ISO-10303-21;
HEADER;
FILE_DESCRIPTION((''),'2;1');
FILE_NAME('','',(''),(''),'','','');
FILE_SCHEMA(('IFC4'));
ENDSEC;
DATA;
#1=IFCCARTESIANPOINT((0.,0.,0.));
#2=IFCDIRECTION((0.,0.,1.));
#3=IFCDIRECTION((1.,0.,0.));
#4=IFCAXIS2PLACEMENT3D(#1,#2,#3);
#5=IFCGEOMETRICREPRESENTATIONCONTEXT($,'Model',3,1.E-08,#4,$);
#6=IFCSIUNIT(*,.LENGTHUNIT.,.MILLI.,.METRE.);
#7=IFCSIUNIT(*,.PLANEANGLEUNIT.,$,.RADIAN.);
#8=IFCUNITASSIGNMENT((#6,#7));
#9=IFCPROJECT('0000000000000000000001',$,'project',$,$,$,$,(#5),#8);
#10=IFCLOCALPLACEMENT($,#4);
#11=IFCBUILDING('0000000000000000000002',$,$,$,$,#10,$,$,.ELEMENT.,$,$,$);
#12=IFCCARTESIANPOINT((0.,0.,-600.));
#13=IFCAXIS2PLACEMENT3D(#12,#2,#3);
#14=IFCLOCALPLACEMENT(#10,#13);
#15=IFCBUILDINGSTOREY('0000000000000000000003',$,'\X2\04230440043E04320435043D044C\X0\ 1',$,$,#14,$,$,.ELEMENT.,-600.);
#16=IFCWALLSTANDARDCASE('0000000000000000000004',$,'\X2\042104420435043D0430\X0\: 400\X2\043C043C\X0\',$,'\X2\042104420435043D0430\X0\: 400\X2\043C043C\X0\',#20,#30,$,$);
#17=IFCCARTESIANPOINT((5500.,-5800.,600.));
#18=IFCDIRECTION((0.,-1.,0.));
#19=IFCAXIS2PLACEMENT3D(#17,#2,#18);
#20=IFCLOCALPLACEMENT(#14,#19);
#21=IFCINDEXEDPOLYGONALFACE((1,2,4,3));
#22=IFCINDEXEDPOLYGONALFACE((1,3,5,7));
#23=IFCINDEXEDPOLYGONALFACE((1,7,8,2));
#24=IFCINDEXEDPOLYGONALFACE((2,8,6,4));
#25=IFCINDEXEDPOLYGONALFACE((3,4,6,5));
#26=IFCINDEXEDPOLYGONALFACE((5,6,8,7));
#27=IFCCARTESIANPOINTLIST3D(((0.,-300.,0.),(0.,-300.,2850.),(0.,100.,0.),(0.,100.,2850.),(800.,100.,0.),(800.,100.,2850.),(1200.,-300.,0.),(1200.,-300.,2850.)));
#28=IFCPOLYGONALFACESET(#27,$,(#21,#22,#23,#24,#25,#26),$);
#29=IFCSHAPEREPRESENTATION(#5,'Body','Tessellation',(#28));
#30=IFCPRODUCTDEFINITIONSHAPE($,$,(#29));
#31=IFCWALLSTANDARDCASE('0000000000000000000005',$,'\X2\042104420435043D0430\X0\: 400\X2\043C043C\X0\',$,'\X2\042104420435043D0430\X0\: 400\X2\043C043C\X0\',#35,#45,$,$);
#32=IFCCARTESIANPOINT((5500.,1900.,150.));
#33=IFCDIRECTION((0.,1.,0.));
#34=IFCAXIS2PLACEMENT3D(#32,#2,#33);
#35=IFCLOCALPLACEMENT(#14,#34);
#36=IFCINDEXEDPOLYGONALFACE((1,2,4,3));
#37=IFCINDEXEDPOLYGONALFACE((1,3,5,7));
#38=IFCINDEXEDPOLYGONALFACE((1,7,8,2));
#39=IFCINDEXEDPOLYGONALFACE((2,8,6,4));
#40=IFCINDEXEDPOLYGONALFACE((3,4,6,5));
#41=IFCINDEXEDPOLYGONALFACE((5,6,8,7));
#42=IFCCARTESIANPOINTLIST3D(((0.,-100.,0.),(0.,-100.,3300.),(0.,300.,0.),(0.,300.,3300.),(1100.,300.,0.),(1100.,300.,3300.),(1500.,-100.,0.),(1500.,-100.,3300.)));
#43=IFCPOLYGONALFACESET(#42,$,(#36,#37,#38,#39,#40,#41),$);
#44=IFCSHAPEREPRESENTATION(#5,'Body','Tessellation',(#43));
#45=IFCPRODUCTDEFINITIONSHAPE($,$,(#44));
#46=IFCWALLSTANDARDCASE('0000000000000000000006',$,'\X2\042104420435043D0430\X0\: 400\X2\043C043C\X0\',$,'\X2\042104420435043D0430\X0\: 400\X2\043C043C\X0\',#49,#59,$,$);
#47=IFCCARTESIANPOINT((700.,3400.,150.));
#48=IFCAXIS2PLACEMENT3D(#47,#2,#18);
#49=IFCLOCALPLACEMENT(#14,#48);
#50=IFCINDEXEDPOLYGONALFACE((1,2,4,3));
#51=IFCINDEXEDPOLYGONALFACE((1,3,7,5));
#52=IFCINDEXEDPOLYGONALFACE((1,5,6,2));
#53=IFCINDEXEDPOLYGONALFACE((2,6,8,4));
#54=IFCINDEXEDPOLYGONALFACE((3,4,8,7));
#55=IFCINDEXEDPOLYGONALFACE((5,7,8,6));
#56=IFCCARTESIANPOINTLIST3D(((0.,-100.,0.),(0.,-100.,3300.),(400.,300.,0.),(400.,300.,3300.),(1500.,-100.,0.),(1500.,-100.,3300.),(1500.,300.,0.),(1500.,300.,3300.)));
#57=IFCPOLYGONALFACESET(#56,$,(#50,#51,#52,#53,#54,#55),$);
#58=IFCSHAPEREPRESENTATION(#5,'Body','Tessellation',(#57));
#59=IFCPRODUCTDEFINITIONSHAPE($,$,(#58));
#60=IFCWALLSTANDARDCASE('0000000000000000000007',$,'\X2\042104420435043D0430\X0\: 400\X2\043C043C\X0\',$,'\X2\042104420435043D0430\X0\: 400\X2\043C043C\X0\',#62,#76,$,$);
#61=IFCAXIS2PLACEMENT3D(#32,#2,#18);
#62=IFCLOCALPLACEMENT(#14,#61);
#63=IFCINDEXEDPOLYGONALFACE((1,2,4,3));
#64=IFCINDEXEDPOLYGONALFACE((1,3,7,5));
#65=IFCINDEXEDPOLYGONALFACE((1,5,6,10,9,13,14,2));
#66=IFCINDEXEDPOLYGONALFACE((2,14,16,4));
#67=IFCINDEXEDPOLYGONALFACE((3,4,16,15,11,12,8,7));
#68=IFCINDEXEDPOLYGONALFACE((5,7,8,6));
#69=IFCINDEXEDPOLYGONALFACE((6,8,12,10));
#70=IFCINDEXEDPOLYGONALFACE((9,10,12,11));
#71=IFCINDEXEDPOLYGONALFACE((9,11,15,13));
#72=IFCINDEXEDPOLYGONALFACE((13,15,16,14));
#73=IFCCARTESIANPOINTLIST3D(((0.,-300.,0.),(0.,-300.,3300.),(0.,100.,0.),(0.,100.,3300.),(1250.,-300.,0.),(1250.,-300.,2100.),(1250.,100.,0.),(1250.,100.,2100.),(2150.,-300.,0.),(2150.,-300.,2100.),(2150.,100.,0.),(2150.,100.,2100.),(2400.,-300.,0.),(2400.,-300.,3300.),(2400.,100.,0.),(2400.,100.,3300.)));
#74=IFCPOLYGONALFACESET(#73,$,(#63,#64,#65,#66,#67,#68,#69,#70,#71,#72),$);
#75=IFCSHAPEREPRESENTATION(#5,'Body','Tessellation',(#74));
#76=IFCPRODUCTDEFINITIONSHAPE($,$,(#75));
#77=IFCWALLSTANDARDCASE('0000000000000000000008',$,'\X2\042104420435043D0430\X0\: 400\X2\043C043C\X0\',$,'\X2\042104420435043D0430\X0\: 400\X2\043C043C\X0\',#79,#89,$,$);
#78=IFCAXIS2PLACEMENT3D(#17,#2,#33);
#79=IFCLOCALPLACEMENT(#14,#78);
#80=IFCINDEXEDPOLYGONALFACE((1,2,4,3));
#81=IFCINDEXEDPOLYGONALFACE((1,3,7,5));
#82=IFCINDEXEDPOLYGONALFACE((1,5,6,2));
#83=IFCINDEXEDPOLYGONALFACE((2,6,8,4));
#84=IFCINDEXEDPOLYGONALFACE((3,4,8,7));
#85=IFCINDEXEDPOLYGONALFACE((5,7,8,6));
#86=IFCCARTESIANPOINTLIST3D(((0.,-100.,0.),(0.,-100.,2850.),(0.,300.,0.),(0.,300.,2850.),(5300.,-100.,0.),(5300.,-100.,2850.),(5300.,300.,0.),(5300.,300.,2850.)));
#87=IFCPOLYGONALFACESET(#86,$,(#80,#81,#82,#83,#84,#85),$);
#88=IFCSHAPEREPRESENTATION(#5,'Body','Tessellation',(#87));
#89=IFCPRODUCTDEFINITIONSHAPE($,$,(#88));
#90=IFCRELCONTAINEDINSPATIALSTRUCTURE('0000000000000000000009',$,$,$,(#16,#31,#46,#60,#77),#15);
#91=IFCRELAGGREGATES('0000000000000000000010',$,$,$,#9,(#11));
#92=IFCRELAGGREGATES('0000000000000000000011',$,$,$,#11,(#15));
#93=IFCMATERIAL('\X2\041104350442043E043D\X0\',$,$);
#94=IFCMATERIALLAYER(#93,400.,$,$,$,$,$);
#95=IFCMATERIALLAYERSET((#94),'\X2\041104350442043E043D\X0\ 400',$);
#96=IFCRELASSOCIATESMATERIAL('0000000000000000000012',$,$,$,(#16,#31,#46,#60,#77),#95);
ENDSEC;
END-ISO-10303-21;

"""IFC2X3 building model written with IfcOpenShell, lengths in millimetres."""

from ifc_helpers import new_model, si_unit, frame, frame_2d, origin_with_axes, place, context, project, spatial, polyline, segment, composite_curve, rectangle, outline, extrude, material, layer, layer_set, layer_usage, element, save


model = new_model("IFC2X3")

# Units and contexts
model_context = context("Model", 3, precision=1e-08, world=origin_with_axes())
ifc_project = project(units=[si_unit("LENGTHUNIT", "METRE", prefix="MILLI"), si_unit("PLANEANGLEUNIT", "RADIAN")], contexts=[model_context])

# Building, storey
building_placement = place(None, origin_with_axes())
building = spatial("IfcBuilding", under=ifc_project, at=building_placement, CompositionType="ELEMENT")
storey_placement = place(building_placement, frame((0.0, 0.0, -600.0), z_axis=(0.0, 0.0, 1.0), x_axis=(1.0, 0.0, 0.0)))
storey = spatial("IfcBuildingStorey", under=building, at=storey_placement, Name="Уровень 1", CompositionType="ELEMENT", Elevation=-600.0)

# Shared definitions
ifc_material_1 = material(Name="Бетон")

# Shared definitions
ifc_layer_1 = layer(ifc_material_1, 400.0)
ifc_layer_set_1 = layer_set([ifc_layer_1], Name="Бетон 400")

# Walls
ifc_layer_usage_1 = layer_usage(ifc_layer_set_1, "AXIS2", "NEGATIVE", 100.0)
wall_1_placement = place(storey_placement, frame((5500.0, -5800.0, 600.0), z_axis=(0.0, 0.0, 1.0), x_axis=(0.0, -1.0, 0.0)))
element("IfcWallStandardCase", 1, at=wall_1_placement, inside=storey, material=ifc_layer_usage_1, Name="Стена: 400мм", ObjectType="Стена: 400мм", context=model_context, shape_type="SweptSolid", body=[
    extrude(outline(composite_curve([segment(polyline([(0.0, -300.0), (1200.0, -300.0)]), True, "CONTINUOUS"), segment(polyline([(1200.0, -300.0), (800.0, 100.0)]), True, "CONTINUOUS"), segment(polyline([(800.0, 100.0), (0.0, 100.0)]), True, "CONTINUOUS"), segment(polyline([(0.0, 100.0), (0.0, -300.0)]), True, "CONTINUOUS")], self_intersect=False)), origin_with_axes(), (0.0, 0.0, 1.0), 2850.0),
])
ifc_layer_usage_2 = layer_usage(ifc_layer_set_1, "AXIS2", "NEGATIVE", 300.0)
wall_2_placement = place(storey_placement, frame((5500.0, 1900.0, 150.0), z_axis=(0.0, 0.0, 1.0), x_axis=(0.0, 1.0, 0.0)))
element("IfcWallStandardCase", 2, at=wall_2_placement, inside=storey, material=ifc_layer_usage_2, Name="Стена: 400мм", ObjectType="Стена: 400мм", context=model_context, shape_type="SweptSolid", body=[
    extrude(outline(composite_curve([segment(polyline([(0.0, -100.0), (1500.0, -100.0)]), True, "CONTINUOUS"), segment(polyline([(1500.0, -100.0), (1100.0, 300.0)]), True, "CONTINUOUS"), segment(polyline([(1100.0, 300.0), (0.0, 300.0)]), True, "CONTINUOUS"), segment(polyline([(0.0, 300.0), (0.0, -100.0)]), True, "CONTINUOUS")], self_intersect=False)), origin_with_axes(), (0.0, 0.0, 1.0), 3300.0),
])

# Wall
ifc_layer_usage_3 = layer_usage(ifc_layer_set_1, "AXIS2", "NEGATIVE", 300.0)
wall_3_placement = place(storey_placement, frame((700.0, 3400.0, 150.0), z_axis=(0.0, 0.0, 1.0), x_axis=(0.0, -1.0, 0.0)))
element("IfcWallStandardCase", 3, at=wall_3_placement, inside=storey, material=ifc_layer_usage_3, Name="Стена: 400мм", ObjectType="Стена: 400мм", context=model_context, shape_type="SweptSolid", body=[
    extrude(outline(composite_curve([segment(polyline([(0.0, -100.0), (1500.0, -100.0)]), True, "CONTINUOUS"), segment(polyline([(1500.0, -100.0), (1500.0, 300.0)]), True, "CONTINUOUS"), segment(polyline([(1500.0, 300.0), (400.0, 300.0)]), True, "CONTINUOUS"), segment(polyline([(400.0, 300.0), (0.0, -100.0)]), True, "CONTINUOUS")], self_intersect=False)), origin_with_axes(), (0.0, 0.0, 1.0), 3300.0),
])

# Wall, opening
ifc_layer_usage_4 = layer_usage(ifc_layer_set_1, "AXIS2", "NEGATIVE", 100.0)
wall_4_placement = place(storey_placement, frame((5500.0, 1900.0, 150.0), z_axis=(0.0, 0.0, 1.0), x_axis=(0.0, -1.0, 0.0)))
wall_4 = element("IfcWallStandardCase", 4, at=wall_4_placement, inside=storey, material=ifc_layer_usage_4, Name="Стена: 400мм", ObjectType="Стена: 400мм", context=model_context, shape_type="SweptSolid", body=[
    extrude(outline(composite_curve([segment(polyline([(0.0, -300.0), (2400.0, -300.0)]), True, "CONTINUOUS"), segment(polyline([(2400.0, -300.0), (2400.0, 100.0)]), True, "CONTINUOUS"), segment(polyline([(2400.0, 100.0), (0.0, 100.0)]), True, "CONTINUOUS"), segment(polyline([(0.0, 100.0), (0.0, -300.0)]), True, "CONTINUOUS")], self_intersect=False)), origin_with_axes(), (0.0, 0.0, 1.0), 3300.0),
])
opening_1_placement = place(wall_4_placement, frame((2150.0, 100.0, 0.0), z_axis=(0.0, 0.0, 1.0), x_axis=(-1.0, 0.0, 0.0)))
element("IfcOpeningElement", 5, at=opening_1_placement, cuts=wall_4, ObjectType="Opening", context=model_context, shape_type="SweptSolid", body=[
    extrude(rectangle(XDim=900.0, YDim=2100.0, at=frame_2d((450.0, 1050.0), x_axis=(1.0, 0.0))), frame((0.0, -5.0, 0.0), z_axis=(0.0, -1.0, 0.0), x_axis=(1.0, 0.0, 0.0)), (0.0, 0.0, -1.0), 410.0),
])

# Wall
ifc_layer_usage_5 = layer_usage(ifc_layer_set_1, "AXIS2", "NEGATIVE", 300.0)
wall_5_placement = place(storey_placement, frame((5500.0, -5800.0, 600.0), z_axis=(0.0, 0.0, 1.0), x_axis=(0.0, 1.0, 0.0)))
element("IfcWallStandardCase", 6, at=wall_5_placement, inside=storey, material=ifc_layer_usage_5, Name="Стена: 400мм", ObjectType="Стена: 400мм", context=model_context, shape_type="SweptSolid", body=[
    extrude(outline(composite_curve([segment(polyline([(0.0, -100.0), (5300.0, -100.0)]), True, "CONTINUOUS"), segment(polyline([(5300.0, -100.0), (5300.0, 300.0)]), True, "CONTINUOUS"), segment(polyline([(5300.0, 300.0), (0.0, 300.0)]), True, "CONTINUOUS"), segment(polyline([(0.0, 300.0), (0.0, -100.0)]), True, "CONTINUOUS")], self_intersect=False)), origin_with_axes(), (0.0, 0.0, 1.0), 2850.0),
])

save(model, "model.ifc")
